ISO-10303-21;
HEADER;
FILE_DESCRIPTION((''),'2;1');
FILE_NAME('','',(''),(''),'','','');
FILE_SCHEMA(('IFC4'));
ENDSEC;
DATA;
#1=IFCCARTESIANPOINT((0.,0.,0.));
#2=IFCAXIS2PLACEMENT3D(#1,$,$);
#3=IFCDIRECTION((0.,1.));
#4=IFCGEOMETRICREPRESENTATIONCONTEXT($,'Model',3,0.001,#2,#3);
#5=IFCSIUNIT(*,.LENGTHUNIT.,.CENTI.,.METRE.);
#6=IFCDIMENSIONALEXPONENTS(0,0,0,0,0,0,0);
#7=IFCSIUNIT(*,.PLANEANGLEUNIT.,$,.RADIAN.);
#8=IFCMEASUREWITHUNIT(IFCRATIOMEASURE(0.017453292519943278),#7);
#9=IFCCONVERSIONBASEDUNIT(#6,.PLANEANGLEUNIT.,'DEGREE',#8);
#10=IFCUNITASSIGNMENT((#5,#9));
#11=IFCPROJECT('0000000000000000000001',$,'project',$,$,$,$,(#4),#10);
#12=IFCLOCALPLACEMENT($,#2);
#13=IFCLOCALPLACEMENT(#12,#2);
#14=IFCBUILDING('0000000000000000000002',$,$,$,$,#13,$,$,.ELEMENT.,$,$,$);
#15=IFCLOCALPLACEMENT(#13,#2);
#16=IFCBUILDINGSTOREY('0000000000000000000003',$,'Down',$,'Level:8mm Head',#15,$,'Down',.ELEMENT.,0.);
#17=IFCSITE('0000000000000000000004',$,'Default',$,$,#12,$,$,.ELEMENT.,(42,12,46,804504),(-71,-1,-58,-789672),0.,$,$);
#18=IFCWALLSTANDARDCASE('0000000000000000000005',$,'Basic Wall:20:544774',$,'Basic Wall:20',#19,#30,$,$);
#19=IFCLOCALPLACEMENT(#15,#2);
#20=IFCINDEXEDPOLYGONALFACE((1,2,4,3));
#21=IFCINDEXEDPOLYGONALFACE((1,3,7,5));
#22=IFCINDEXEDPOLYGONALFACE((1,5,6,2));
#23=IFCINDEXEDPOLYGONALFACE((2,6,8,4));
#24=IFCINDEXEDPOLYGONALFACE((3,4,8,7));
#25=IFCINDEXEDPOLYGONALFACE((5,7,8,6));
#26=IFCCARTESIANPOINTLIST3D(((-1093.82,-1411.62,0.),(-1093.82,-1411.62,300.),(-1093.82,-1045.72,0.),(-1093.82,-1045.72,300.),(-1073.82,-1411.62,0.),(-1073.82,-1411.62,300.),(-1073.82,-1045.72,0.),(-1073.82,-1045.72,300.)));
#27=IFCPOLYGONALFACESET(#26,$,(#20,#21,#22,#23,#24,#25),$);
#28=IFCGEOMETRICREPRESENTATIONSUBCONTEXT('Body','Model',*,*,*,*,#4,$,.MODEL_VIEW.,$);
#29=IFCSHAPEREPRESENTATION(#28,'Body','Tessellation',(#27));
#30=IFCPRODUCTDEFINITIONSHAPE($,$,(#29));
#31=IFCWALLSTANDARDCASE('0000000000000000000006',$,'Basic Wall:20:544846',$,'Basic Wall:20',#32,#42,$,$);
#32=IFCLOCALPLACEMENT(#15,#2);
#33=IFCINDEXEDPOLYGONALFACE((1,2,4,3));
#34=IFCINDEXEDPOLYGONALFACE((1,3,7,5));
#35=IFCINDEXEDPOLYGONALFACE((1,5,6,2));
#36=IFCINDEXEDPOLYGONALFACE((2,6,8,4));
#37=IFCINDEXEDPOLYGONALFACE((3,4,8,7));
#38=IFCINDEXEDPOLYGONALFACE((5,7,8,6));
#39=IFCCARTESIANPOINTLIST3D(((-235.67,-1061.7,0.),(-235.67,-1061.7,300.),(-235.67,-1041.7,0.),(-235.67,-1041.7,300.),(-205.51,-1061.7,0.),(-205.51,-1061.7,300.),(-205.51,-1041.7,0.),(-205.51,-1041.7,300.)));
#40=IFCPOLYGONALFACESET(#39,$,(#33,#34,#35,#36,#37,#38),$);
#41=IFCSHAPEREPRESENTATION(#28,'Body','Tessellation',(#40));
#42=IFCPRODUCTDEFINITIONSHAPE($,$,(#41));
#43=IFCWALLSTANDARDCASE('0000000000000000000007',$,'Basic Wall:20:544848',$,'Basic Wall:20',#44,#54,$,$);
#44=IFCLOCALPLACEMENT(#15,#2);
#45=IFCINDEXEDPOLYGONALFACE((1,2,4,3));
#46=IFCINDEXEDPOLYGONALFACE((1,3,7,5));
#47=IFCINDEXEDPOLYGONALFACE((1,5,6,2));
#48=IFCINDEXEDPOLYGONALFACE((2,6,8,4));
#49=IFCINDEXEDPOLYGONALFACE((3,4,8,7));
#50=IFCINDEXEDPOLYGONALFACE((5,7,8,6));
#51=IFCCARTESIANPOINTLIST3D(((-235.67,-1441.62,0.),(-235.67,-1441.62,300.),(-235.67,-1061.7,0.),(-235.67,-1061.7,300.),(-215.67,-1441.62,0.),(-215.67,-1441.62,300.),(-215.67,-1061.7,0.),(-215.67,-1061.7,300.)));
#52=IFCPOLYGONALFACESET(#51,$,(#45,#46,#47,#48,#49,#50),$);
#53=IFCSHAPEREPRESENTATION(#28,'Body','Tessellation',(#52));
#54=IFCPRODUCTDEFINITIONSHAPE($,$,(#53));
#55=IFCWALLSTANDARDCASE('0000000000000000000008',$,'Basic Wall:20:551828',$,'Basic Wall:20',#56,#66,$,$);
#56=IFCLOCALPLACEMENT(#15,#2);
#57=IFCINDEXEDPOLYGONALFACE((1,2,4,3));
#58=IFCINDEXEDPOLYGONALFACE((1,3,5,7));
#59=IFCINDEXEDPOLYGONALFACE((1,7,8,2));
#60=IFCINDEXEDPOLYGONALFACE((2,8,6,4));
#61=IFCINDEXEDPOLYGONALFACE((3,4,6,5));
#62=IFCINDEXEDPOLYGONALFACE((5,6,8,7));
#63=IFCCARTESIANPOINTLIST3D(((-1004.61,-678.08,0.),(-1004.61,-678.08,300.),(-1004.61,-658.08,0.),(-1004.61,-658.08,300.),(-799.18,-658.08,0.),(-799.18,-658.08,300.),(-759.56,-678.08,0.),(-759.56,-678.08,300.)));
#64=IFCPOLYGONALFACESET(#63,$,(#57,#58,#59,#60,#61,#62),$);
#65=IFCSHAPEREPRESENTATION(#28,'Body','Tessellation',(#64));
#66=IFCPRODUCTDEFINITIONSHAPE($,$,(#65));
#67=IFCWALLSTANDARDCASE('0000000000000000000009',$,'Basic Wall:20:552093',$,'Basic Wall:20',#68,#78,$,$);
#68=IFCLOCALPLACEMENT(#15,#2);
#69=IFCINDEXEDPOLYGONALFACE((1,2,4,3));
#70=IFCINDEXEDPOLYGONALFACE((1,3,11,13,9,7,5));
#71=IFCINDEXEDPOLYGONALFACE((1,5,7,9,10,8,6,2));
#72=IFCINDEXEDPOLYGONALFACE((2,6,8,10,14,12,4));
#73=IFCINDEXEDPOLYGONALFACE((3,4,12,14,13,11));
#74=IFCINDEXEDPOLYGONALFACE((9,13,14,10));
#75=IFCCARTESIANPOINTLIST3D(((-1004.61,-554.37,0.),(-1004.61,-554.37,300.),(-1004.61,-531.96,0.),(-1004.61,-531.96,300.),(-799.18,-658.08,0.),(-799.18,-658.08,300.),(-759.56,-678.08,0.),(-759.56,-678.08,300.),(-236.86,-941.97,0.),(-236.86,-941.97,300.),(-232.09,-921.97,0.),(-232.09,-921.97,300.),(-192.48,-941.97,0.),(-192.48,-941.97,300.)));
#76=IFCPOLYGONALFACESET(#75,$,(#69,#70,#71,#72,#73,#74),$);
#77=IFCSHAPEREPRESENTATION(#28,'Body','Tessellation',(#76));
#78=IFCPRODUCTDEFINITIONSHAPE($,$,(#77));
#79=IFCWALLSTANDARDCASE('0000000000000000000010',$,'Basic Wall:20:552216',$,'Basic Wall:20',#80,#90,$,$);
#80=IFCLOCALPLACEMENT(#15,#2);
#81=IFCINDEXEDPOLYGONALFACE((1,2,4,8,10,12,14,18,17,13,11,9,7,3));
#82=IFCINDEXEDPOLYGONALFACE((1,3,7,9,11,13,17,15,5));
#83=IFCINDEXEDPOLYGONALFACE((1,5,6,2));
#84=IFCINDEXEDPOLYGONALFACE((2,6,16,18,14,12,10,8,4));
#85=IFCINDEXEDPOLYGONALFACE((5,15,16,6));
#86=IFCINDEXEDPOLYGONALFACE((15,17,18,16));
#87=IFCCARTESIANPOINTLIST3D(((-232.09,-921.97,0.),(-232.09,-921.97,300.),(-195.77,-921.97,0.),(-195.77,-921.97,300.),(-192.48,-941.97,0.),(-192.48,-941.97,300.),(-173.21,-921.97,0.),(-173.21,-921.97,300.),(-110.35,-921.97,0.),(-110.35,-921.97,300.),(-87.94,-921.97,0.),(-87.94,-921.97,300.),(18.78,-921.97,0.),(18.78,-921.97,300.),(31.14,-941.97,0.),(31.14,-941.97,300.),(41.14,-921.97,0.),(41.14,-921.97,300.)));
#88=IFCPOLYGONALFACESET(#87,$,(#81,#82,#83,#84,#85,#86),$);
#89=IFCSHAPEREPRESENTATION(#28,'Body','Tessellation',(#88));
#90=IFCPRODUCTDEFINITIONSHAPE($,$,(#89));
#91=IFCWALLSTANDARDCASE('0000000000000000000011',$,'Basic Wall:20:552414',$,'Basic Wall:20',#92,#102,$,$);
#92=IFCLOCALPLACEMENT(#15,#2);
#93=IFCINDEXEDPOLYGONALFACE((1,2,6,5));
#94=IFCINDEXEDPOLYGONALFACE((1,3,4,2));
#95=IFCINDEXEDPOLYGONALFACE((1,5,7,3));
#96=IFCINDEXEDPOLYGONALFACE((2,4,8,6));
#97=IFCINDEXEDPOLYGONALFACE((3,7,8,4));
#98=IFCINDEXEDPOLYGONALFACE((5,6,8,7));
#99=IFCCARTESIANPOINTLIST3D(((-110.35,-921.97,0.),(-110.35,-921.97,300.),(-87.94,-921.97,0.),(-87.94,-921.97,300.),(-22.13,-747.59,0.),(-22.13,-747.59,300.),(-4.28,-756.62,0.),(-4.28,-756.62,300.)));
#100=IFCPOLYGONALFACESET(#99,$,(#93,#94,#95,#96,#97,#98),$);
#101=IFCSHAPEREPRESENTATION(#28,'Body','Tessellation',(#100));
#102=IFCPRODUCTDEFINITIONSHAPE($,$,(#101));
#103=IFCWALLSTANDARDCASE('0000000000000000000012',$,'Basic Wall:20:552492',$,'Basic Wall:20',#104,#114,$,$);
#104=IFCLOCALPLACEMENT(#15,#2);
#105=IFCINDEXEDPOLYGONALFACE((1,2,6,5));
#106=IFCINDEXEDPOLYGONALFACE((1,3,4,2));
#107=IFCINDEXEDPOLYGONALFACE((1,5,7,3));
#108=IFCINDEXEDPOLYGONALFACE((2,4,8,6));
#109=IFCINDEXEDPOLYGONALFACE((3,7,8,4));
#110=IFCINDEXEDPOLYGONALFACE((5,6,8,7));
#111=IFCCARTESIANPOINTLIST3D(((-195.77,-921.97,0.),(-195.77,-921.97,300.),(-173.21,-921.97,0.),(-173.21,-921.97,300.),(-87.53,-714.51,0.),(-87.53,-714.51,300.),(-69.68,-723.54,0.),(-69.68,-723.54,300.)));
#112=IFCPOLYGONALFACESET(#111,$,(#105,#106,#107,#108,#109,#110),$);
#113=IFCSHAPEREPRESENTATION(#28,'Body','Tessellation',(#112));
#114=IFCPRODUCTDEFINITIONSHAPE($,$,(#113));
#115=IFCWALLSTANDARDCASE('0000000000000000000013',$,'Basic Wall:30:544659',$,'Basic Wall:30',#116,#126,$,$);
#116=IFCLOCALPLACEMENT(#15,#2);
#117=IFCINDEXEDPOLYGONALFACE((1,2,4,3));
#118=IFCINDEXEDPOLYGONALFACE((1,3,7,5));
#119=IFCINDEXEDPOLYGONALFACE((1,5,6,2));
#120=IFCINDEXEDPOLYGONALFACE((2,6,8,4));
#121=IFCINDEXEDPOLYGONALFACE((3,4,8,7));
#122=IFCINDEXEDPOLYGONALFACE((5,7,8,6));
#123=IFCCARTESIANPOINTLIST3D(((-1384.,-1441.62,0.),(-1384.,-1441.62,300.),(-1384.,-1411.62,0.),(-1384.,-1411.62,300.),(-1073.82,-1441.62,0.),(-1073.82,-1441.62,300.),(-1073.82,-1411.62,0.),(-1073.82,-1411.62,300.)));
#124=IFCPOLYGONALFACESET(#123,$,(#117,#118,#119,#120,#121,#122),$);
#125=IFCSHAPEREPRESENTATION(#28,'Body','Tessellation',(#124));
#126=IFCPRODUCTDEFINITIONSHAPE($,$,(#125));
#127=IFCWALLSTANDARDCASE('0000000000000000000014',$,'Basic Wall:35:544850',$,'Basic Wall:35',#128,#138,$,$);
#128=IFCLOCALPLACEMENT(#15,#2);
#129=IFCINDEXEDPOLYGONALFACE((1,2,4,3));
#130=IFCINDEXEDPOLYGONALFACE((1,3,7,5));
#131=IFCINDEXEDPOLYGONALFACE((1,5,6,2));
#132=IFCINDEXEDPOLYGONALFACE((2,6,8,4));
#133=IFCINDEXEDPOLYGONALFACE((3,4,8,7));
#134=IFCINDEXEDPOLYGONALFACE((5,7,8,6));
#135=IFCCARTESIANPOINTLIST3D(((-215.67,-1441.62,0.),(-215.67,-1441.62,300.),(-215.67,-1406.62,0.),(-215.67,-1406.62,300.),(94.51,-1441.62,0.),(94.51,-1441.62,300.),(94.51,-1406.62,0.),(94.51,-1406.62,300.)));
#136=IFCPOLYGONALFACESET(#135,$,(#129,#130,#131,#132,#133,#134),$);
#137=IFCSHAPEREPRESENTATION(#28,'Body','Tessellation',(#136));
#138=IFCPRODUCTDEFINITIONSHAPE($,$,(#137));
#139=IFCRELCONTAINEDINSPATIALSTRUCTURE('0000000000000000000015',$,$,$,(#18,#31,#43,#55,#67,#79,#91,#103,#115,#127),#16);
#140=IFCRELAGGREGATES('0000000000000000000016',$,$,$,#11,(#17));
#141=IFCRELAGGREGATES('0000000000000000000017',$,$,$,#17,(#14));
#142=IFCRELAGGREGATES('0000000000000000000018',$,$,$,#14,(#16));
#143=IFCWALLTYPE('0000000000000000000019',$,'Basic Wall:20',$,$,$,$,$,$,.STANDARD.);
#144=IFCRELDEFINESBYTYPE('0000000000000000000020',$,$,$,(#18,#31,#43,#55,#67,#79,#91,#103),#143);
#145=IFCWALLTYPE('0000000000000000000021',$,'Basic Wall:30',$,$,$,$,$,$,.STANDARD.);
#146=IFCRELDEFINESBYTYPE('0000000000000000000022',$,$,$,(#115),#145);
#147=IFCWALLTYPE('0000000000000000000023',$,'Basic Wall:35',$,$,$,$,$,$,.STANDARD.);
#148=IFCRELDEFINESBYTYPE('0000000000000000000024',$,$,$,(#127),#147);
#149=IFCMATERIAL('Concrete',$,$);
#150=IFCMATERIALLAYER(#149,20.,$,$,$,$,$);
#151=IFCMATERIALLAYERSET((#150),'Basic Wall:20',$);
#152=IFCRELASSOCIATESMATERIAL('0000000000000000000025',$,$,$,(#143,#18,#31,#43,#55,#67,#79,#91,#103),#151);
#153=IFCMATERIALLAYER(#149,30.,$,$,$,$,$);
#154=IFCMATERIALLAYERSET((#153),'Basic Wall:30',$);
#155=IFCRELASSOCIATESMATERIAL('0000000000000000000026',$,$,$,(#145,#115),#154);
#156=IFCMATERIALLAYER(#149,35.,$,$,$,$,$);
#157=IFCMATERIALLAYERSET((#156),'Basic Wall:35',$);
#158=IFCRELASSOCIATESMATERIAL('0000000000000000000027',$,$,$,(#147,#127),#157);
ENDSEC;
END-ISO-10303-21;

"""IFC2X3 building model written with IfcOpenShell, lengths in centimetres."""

from ifc_helpers import new_model, entity, si_unit, converted_unit, direction, frame, frame_2d, origin, place, context, subcontext, project, spatial, polyline, rectangle, outline, extrude, material, layer, layer_set, layer_usage, type_object, element, save


model = new_model("IFC2X3")

# Units and contexts
model_context = context("Model", 3, precision=0.001, world=origin(), true_north=direction((0.0, 1.0)))
body_context = subcontext(model_context, "Body", "Model", "MODEL_VIEW")
ifc_project = project(units=[si_unit("LENGTHUNIT", "METRE", prefix="CENTI"), converted_unit("PLANEANGLEUNIT", "DEGREE", entity("IfcRatioMeasure", 0.017453292519943278), si_unit("PLANEANGLEUNIT", "RADIAN"), dimensions=[0, 0, 0, 0, 0, 0, 0])], contexts=[model_context])

# Site, building, storey
site_placement = place(None, origin())
site = spatial("IfcSite", under=ifc_project, at=site_placement, Name="Default", CompositionType="ELEMENT", RefLatitude=(42, 12, 46, 804504), RefLongitude=(-71, -1, -58, -789672), RefElevation=0.0)
building_placement = place(site_placement, origin())
building = spatial("IfcBuilding", under=site, at=building_placement, CompositionType="ELEMENT")
storey_placement = place(building_placement, origin())
storey = spatial("IfcBuildingStorey", under=building, at=storey_placement, Name="Down", ObjectType="Level:8mm Head", LongName="Down", CompositionType="ELEMENT", Elevation=0.0)

# Walls
ifc_material = material(Name="Concrete")
ifc_layer_1 = layer(ifc_material, 20.0)
ifc_layer_set_1 = layer_set([ifc_layer_1], Name="Basic Wall:20")
wall_type_1 = type_object("IfcWallType", Name="Basic Wall:20", PredefinedType="STANDARD", material=ifc_layer_set_1)
ifc_layer_usage_1 = layer_usage(ifc_layer_set_1, "AXIS2", "POSITIVE", -10.0)
wall_1_placement = place(storey_placement, frame((-1083.82, -1411.62, 0.0), z_axis=(0.0, 0.0, 1.0), x_axis=(0.0, 1.0, 0.0)))
element("IfcWallStandardCase", 1, at=wall_1_placement, inside=storey, type_object=wall_type_1, material=ifc_layer_usage_1, Name="Basic Wall:20:544774", ObjectType="Basic Wall:20", context=body_context, shape_type="SweptSolid", body=[
    extrude(rectangle(XDim=365.9, YDim=20.0, at=frame_2d((182.95, 0.0), x_axis=(-1.0, 0.0))), origin(), (0.0, 0.0, 1.0), 300.0),
])
ifc_layer_usage_2 = layer_usage(ifc_layer_set_1, "AXIS2", "NEGATIVE", 10.0)
wall_2_placement = place(storey_placement, frame((-205.51, -1051.7, 0.0), z_axis=(0.0, 0.0, 1.0), x_axis=(-1.0, 0.0, 0.0)))
element("IfcWallStandardCase", 2, at=wall_2_placement, inside=storey, type_object=wall_type_1, material=ifc_layer_usage_2, Name="Basic Wall:20:544846", ObjectType="Basic Wall:20", context=body_context, shape_type="SweptSolid", body=[
    extrude(rectangle(XDim=30.16, YDim=20.0, at=frame_2d((15.08, 0.0), x_axis=(-1.0, 0.0))), origin(), (0.0, 0.0, 1.0), 300.0),
])
ifc_layer_usage_3 = layer_usage(ifc_layer_set_1, "AXIS2", "POSITIVE", -10.0)
wall_3_placement = place(storey_placement, frame((-225.67, -1061.7, 0.0), z_axis=(0.0, 0.0, 1.0), x_axis=(0.0, -1.0, 0.0)))
element("IfcWallStandardCase", 3, at=wall_3_placement, inside=storey, type_object=wall_type_1, material=ifc_layer_usage_3, Name="Basic Wall:20:544848", ObjectType="Basic Wall:20", context=body_context, shape_type="SweptSolid", body=[
    extrude(rectangle(XDim=379.92, YDim=20.0, at=frame_2d((189.96, 0.0), x_axis=(-1.0, 0.0))), origin(), (0.0, 0.0, 1.0), 300.0),
])
ifc_layer_usage_4 = layer_usage(ifc_layer_set_1, "AXIS2", "POSITIVE", -10.0)
wall_4_placement = place(storey_placement, frame((-1004.61, -668.08, 0.0)))
element("IfcWallStandardCase", 4, at=wall_4_placement, inside=storey, type_object=wall_type_1, material=ifc_layer_usage_4, Name="Basic Wall:20:551828", ObjectType="Basic Wall:20", context=body_context, shape_type="SweptSolid", body=[
    extrude(outline(polyline([(245.05, -10.0), (205.43, 10.0), (0.0, 10.0), (0.0, -10.0), (245.05, -10.0)])), origin(), (0.0, 0.0, 1.0), 300.0),
])
ifc_layer_usage_5 = layer_usage(ifc_layer_set_1, "AXIS2", "POSITIVE", -10.0)
wall_5_placement = place(storey_placement, frame((-1009.12, -540.89, 0.0), z_axis=(0.0, 0.0, 1.0), x_axis=(0.892687, -0.450677, 0.0)))
element("IfcWallStandardCase", 5, at=wall_5_placement, inside=storey, type_object=wall_type_1, material=ifc_layer_usage_5, Name="Basic Wall:20:552093", ObjectType="Basic Wall:20", context=body_context, shape_type="SweptSolid", body=[
    extrude(outline(polyline([(870.15, -10.0), (909.76, 10.0), (865.38, 10.0), (0.0, 10.0), (10.1, -10.0), (240.23, -10.0), (284.6, -10.0), (870.15, -10.0)])), origin(), (0.0, 0.0, 1.0), 300.0),
])
ifc_layer_usage_6 = layer_usage(ifc_layer_set_1, "AXIS2", "POSITIVE", -10.0)
wall_6_placement = place(storey_placement, frame((-232.09, -931.97, 0.0)))
element("IfcWallStandardCase", 6, at=wall_6_placement, inside=storey, type_object=wall_type_1, material=ifc_layer_usage_6, Name="Basic Wall:20:552216", ObjectType="Basic Wall:20", context=body_context, shape_type="SweptSolid", body=[
    extrude(outline(polyline([(263.24, -10.0), (273.24, 10.0), (250.88, 10.0), (144.16, 10.0), (121.74, 10.0), (58.88, 10.0), (36.32, 10.0), (0.0, 10.0), (39.62, -10.0), (263.24, -10.0)])), origin(), (0.0, 0.0, 1.0), 300.0),
])
ifc_layer_usage_7 = layer_usage(ifc_layer_set_1, "AXIS2", "POSITIVE", -10.0)
wall_7_placement = place(storey_placement, frame((-101.43, -926.49, 0.0), z_axis=(0.0, 0.0, 1.0), x_axis=(0.451441, 0.892301, 0.0)))
element("IfcWallStandardCase", 7, at=wall_7_placement, inside=storey, type_object=wall_type_1, material=ifc_layer_usage_7, Name="Basic Wall:20:552414", ObjectType="Basic Wall:20", context=body_context, shape_type="SweptSolid", body=[
    extrude(outline(polyline([(195.42, -10.0), (195.42, 10.0), (0.0, 10.0), (10.12, -10.0), (195.42, -10.0)])), origin(), (0.0, 0.0, 1.0), 300.0),
])
ifc_layer_usage_8 = layer_usage(ifc_layer_set_1, "AXIS2", "POSITIVE", -10.0)
wall_8_placement = place(storey_placement, frame((-186.9, -926.6, 0.0), z_axis=(0.0, 0.0, 1.0), x_axis=(0.462566, 0.886585, 0.0)))
element("IfcWallStandardCase", 8, at=wall_8_placement, inside=storey, type_object=wall_type_1, material=ifc_layer_usage_8, Name="Basic Wall:20:552492", ObjectType="Basic Wall:20", context=body_context, shape_type="SweptSolid", body=[
    extrude(outline(polyline([(234.26, -10.0), (234.0, 10.0), (0.0, 10.0), (10.43, -10.0), (234.26, -10.0)])), origin(), (0.0, 0.0, 1.0), 300.0),
])
ifc_layer_2 = layer(ifc_material, 30.0)
ifc_layer_set_2 = layer_set([ifc_layer_2], Name="Basic Wall:30")
ifc_layer_usage_9 = layer_usage(ifc_layer_set_2, "AXIS2", "POSITIVE", -15.0)
wall_type_2 = type_object("IfcWallType", Name="Basic Wall:30", PredefinedType="STANDARD", material=ifc_layer_set_2)
wall_9_placement = place(storey_placement, frame((-1384.0, -1426.62, 0.0)))
element("IfcWallStandardCase", 9, at=wall_9_placement, inside=storey, type_object=wall_type_2, material=ifc_layer_usage_9, Name="Basic Wall:30:544659", ObjectType="Basic Wall:30", context=body_context, shape_type="SweptSolid", body=[
    extrude(rectangle(XDim=310.18, YDim=30.0, at=frame_2d((155.09, 0.0), x_axis=(-1.0, 0.0))), origin(), (0.0, 0.0, 1.0), 300.0),
])
ifc_layer_3 = layer(ifc_material, 35.0)
ifc_layer_set_3 = layer_set([ifc_layer_3], Name="Basic Wall:35")
ifc_layer_usage_10 = layer_usage(ifc_layer_set_3, "AXIS2", "POSITIVE", -17.5)
wall_type_3 = type_object("IfcWallType", Name="Basic Wall:35", PredefinedType="STANDARD", material=ifc_layer_set_3)
wall_10_placement = place(storey_placement, frame((-215.67, -1424.12, 0.0)))
element("IfcWallStandardCase", 10, at=wall_10_placement, inside=storey, type_object=wall_type_3, material=ifc_layer_usage_10, Name="Basic Wall:35:544850", ObjectType="Basic Wall:35", context=body_context, shape_type="SweptSolid", body=[
    extrude(rectangle(XDim=310.18, YDim=35.0, at=frame_2d((155.09, 0.0), x_axis=(-1.0, 0.0))), origin(), (0.0, 0.0, 1.0), 300.0),
])

save(model, "model.ifc")
